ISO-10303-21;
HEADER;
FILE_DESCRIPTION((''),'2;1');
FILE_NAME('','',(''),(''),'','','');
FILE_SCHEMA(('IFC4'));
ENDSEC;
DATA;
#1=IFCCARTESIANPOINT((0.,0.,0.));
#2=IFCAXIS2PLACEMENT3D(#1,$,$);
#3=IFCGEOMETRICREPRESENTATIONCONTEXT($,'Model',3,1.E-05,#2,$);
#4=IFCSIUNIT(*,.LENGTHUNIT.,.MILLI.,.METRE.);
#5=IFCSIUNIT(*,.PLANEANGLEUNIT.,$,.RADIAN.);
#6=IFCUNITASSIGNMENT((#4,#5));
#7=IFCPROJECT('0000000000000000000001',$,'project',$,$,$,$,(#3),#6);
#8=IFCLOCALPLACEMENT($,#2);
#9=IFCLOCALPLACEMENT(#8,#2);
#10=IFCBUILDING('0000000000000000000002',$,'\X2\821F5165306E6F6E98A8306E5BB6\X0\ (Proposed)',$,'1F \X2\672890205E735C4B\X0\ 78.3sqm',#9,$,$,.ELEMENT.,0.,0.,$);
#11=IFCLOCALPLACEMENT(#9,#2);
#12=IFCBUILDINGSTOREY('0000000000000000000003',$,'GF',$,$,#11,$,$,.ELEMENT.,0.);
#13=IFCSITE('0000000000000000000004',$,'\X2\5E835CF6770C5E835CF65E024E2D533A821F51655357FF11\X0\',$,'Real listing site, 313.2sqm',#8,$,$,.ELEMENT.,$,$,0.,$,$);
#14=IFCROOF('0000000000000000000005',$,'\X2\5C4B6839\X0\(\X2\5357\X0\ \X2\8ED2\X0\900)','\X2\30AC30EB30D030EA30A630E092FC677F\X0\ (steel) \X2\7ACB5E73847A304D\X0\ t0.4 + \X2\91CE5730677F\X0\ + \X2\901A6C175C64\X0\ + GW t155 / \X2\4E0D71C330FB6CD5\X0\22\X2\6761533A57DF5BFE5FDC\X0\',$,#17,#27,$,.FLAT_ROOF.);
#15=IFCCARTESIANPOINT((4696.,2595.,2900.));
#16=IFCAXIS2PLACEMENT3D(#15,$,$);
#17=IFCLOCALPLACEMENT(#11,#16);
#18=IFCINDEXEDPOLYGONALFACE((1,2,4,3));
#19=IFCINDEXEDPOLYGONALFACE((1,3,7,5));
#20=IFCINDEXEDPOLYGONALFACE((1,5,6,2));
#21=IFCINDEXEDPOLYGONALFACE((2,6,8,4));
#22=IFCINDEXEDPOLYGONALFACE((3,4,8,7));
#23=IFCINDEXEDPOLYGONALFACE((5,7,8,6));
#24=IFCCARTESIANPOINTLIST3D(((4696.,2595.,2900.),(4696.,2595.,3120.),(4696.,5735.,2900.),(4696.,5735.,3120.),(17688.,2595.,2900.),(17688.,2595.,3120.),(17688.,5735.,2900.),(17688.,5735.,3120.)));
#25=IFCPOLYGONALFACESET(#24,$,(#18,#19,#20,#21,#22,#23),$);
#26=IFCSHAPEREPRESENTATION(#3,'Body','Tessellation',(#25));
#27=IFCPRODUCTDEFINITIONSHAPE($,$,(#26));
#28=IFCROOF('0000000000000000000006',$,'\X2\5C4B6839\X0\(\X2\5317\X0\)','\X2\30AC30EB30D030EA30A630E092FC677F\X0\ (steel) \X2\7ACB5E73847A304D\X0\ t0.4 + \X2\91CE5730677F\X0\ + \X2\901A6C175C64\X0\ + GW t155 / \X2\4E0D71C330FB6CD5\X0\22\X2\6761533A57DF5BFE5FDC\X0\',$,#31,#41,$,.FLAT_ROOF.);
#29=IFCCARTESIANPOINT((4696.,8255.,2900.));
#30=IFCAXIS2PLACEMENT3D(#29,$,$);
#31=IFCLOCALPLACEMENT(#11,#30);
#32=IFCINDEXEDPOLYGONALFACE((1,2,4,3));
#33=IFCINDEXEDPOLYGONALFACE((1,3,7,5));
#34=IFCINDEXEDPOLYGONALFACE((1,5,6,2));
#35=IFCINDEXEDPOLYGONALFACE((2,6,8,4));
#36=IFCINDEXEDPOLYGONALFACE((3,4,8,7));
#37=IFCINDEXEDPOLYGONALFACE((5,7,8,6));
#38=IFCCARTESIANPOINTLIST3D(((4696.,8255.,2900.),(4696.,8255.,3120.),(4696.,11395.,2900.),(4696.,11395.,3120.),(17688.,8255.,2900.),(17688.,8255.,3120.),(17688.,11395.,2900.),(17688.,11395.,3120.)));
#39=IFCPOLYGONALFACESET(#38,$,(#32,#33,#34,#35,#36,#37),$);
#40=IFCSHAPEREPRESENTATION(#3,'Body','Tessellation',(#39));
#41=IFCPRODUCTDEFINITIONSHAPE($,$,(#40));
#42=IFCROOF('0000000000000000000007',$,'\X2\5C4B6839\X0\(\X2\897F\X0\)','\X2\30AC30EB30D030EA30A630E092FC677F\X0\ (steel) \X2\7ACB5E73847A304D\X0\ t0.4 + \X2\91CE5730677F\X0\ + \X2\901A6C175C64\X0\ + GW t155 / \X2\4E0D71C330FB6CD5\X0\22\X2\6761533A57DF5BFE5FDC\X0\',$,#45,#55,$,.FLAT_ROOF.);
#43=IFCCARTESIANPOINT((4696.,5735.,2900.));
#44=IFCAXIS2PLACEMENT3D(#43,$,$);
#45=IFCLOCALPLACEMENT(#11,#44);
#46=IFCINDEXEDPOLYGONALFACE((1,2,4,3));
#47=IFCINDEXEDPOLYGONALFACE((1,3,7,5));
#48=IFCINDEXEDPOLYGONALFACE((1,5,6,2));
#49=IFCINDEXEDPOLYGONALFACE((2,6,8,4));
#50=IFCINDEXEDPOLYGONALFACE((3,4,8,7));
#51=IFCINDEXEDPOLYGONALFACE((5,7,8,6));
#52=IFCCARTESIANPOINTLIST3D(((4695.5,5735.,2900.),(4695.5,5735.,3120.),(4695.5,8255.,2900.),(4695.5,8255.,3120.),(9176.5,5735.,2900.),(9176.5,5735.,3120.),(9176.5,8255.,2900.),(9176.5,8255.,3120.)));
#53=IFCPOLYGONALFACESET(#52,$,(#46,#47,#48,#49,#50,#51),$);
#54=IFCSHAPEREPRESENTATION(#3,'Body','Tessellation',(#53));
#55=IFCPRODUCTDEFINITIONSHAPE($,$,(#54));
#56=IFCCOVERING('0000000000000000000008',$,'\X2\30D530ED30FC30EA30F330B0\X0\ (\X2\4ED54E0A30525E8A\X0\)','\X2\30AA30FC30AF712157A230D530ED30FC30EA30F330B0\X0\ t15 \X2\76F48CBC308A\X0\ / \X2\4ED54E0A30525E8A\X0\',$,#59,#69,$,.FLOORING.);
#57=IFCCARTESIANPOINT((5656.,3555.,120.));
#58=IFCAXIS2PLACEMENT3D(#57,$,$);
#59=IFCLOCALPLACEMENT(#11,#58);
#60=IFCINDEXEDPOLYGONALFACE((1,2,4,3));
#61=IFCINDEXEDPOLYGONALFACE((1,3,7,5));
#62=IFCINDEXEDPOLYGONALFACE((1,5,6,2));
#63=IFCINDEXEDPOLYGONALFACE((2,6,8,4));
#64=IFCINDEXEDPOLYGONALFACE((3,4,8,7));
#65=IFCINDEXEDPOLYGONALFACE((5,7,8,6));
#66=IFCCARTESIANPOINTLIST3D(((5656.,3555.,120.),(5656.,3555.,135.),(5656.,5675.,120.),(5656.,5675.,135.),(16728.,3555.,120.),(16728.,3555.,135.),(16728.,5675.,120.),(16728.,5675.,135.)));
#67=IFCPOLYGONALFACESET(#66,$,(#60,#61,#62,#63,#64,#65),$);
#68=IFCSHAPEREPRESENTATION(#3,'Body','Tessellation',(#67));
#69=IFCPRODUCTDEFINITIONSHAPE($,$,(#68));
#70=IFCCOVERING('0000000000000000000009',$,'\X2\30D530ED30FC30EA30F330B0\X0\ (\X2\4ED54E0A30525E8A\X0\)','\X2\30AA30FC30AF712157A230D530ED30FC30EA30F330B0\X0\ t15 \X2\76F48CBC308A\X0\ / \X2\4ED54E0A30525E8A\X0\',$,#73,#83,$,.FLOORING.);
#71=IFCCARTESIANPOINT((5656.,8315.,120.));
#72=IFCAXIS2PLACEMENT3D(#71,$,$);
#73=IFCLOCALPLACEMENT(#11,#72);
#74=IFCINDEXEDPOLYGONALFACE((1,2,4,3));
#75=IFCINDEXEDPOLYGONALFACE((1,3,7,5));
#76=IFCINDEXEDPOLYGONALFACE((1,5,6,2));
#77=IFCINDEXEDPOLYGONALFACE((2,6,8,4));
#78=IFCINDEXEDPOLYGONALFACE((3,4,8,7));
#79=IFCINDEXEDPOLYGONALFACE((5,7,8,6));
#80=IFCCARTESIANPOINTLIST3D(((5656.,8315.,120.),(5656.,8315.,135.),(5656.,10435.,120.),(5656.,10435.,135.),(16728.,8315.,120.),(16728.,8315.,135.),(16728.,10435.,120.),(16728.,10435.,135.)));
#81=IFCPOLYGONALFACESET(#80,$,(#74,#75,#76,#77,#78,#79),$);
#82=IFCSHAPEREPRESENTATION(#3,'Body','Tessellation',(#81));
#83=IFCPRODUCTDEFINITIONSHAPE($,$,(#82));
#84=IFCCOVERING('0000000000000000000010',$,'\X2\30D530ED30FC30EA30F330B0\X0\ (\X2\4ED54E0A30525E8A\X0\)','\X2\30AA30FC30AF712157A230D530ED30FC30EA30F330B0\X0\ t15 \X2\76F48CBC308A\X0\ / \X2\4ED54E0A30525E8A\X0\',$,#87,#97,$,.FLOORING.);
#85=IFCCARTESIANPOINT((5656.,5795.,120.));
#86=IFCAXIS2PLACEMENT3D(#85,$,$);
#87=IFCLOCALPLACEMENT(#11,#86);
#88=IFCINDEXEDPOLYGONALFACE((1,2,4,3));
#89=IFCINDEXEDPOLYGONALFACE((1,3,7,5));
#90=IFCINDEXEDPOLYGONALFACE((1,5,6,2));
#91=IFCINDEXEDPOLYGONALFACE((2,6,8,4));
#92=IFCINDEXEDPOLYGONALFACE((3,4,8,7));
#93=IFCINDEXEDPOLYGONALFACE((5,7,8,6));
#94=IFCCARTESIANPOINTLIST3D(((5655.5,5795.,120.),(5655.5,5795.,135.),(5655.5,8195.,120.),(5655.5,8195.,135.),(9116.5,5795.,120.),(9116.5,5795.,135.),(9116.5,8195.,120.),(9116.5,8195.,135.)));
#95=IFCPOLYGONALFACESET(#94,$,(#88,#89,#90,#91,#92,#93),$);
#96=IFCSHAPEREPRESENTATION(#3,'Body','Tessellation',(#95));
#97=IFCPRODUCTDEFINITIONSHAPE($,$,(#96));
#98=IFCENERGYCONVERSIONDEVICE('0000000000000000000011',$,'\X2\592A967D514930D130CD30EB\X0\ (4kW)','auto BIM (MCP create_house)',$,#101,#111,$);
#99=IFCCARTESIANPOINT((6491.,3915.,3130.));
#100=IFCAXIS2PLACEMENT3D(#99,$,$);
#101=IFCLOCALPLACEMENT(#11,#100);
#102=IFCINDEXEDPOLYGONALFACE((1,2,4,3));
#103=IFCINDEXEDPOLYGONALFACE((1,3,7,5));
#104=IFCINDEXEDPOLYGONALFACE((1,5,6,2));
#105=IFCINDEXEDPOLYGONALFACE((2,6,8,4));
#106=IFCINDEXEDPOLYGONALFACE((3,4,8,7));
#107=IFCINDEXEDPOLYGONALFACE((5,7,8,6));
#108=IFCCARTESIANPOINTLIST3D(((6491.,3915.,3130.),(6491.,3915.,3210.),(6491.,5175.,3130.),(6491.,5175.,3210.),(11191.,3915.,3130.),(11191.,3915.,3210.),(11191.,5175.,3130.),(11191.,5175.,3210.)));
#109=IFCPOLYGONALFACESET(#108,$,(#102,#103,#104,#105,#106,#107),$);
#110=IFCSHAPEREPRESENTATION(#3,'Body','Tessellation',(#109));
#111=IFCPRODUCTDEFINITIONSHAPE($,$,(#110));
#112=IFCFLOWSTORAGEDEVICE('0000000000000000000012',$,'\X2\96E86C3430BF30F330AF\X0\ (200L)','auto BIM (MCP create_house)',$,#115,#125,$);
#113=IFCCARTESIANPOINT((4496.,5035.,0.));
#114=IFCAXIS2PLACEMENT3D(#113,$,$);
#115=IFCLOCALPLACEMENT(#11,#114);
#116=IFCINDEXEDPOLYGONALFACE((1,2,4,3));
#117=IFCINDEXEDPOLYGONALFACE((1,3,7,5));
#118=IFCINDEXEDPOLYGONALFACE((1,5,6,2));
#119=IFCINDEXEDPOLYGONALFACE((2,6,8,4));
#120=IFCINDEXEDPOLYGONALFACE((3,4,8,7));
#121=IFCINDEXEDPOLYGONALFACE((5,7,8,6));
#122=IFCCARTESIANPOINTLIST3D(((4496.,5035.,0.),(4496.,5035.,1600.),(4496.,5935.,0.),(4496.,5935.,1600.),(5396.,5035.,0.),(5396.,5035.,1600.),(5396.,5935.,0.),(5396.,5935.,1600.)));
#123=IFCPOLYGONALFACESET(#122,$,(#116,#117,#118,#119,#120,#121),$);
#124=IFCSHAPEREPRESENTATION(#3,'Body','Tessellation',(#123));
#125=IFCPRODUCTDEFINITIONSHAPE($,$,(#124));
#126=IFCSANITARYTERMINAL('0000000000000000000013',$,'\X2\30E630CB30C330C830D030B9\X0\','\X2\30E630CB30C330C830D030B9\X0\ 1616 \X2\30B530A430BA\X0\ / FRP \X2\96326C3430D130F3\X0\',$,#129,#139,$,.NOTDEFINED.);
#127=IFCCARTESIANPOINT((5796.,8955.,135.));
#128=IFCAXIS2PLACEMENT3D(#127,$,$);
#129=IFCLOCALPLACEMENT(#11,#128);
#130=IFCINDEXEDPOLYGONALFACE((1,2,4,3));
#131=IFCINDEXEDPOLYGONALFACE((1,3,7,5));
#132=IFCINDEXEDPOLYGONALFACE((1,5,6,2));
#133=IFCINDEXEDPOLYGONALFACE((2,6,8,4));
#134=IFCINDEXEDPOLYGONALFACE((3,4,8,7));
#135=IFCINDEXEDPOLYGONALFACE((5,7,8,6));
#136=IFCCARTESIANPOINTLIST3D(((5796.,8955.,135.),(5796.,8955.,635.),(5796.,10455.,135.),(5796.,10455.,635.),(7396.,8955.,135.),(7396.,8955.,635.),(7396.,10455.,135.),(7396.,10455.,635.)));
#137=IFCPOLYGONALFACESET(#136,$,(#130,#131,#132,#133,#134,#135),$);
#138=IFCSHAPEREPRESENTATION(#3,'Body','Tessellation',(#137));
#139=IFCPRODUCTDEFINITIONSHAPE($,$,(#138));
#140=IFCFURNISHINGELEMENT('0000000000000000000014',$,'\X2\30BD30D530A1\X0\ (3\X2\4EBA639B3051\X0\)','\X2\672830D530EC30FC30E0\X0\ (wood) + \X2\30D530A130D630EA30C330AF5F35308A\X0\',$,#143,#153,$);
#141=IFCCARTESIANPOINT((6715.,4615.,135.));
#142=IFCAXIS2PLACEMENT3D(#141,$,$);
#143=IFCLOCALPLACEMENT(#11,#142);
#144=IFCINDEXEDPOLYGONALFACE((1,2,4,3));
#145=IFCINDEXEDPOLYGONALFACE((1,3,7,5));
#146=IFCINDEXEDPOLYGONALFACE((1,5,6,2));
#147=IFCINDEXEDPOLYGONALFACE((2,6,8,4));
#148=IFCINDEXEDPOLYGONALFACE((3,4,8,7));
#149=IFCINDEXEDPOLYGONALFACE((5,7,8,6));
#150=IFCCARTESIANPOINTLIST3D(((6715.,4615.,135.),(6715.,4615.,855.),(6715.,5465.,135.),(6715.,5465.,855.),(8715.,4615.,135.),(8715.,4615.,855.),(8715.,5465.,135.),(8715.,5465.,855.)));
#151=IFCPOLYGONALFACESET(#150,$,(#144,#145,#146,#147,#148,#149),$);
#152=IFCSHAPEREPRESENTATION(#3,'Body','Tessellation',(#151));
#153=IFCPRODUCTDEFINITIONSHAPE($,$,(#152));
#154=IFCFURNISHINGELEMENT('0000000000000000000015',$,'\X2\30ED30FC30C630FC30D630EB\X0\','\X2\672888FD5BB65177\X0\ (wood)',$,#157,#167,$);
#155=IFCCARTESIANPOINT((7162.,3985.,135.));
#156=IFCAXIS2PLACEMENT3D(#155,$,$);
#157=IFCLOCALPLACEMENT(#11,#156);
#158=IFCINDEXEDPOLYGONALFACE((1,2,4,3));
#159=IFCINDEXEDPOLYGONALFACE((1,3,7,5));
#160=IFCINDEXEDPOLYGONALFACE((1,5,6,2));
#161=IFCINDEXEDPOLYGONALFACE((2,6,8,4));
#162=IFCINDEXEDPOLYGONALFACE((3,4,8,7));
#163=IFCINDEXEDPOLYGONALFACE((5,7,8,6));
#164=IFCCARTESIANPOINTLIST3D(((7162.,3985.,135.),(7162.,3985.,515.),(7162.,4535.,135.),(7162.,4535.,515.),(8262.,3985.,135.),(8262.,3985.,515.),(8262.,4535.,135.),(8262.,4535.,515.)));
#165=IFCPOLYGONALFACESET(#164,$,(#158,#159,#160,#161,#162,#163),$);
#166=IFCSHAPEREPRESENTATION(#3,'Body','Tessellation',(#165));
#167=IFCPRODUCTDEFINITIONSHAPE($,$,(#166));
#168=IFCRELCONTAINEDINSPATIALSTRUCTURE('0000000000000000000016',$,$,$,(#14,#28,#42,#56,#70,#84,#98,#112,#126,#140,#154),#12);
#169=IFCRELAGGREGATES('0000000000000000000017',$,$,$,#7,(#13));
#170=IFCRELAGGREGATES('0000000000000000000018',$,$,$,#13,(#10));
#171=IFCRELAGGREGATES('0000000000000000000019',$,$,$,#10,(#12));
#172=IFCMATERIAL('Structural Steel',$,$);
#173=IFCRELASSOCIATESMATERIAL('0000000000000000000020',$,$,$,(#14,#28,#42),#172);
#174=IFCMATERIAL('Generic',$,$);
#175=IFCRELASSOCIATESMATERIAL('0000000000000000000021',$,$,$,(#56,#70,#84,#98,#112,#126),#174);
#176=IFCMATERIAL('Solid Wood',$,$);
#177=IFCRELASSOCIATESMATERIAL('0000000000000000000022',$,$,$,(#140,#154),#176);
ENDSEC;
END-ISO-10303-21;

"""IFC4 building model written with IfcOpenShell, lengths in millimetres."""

from ifc_helpers import new_model, si_unit, frame, frame_2d, origin, place, context, project, spatial, rectangle, extrude, material, element, save


model = new_model("IFC4")

# Units and contexts
model_context = context("Model", 3, precision=1e-05, world=origin())
ifc_project = project(units=[si_unit("LENGTHUNIT", "METRE", prefix="MILLI"), si_unit("PLANEANGLEUNIT", "RADIAN")], contexts=[model_context])

# Site, building, storey
site_placement = place(None, origin())
site = spatial("IfcSite", under=ifc_project, at=site_placement, Name="広島県広島市中区舟入南１", ObjectType="Real listing site, 313.2sqm", CompositionType="ELEMENT", RefElevation=0.0)
building_placement = place(site_placement, origin())
building = spatial("IfcBuilding", under=site, at=building_placement, Name="舟入の潮風の家 (Proposed)", ObjectType="1F 木造平屋 78.3sqm", CompositionType="ELEMENT", ElevationOfRefHeight=0.0, ElevationOfTerrain=0.0)
storey_placement = place(building_placement, origin())
storey = spatial("IfcBuildingStorey", under=building, at=storey_placement, Name="GF", CompositionType="ELEMENT", Elevation=0.0)

# Shared definitions
ifc_material_1 = material(Name="Solid Wood")

# Roofs
ifc_material_2 = material(Name="Structural Steel")
roof_1_placement = place(storey_placement, frame((4696.0, 2595.0, 2900.0)))
element("IfcRoof", 1, at=roof_1_placement, inside=storey, material=ifc_material_2, Name="屋根(南 軒900)", Description="ガルバリウム鋼板 (steel) 立平葺き t0.4 + 野地板 + 通気層 + GW t155 / 不燃・法22条区域対応", PredefinedType="FLAT_ROOF", context=model_context, shape_type="SweptSolid", body=[
    extrude(rectangle(XDim=12992.0, YDim=3140.0, at=frame_2d((6496.0, 1570.0))), frame((4696.0, 2595.0, 2900.0)), (0.0, 0.0, 1.0), 220.0),
])
roof_2_placement = place(storey_placement, frame((4696.0, 8255.0, 2900.0)))
element("IfcRoof", 2, at=roof_2_placement, inside=storey, material=ifc_material_2, Name="屋根(北)", Description="ガルバリウム鋼板 (steel) 立平葺き t0.4 + 野地板 + 通気層 + GW t155 / 不燃・法22条区域対応", PredefinedType="FLAT_ROOF", context=model_context, shape_type="SweptSolid", body=[
    extrude(rectangle(XDim=12992.0, YDim=3140.0, at=frame_2d((6496.0, 1570.0))), frame((4696.0, 8255.0, 2900.0)), (0.0, 0.0, 1.0), 220.0),
])
roof_3_placement = place(storey_placement, frame((4696.0, 5735.0, 2900.0)))
element("IfcRoof", 3, at=roof_3_placement, inside=storey, material=ifc_material_2, Name="屋根(西)", Description="ガルバリウム鋼板 (steel) 立平葺き t0.4 + 野地板 + 通気層 + GW t155 / 不燃・法22条区域対応", PredefinedType="FLAT_ROOF", context=model_context, shape_type="SweptSolid", body=[
    extrude(rectangle(XDim=4481.0, YDim=2520.0, at=frame_2d((2240.0, 1260.0))), frame((4696.0, 5735.0, 2900.0)), (0.0, 0.0, 1.0), 220.0),
])

# Coverings
ifc_material_3 = material(Name="Generic")
covering_1_placement = place(storey_placement, frame((5656.0, 3555.0, 120.0)))
element("IfcCovering", 4, at=covering_1_placement, inside=storey, material=ifc_material_3, Name="フローリング (仕上げ床)", Description="オーク無垢フローリング t15 直貼り / 仕上げ床", PredefinedType="FLOORING", context=model_context, shape_type="SweptSolid", body=[
    extrude(rectangle(XDim=11072.0, YDim=2120.0, at=frame_2d((5536.0, 1060.0))), frame((5656.0, 3555.0, 120.0)), (0.0, 0.0, 1.0), 15.0),
])
covering_2_placement = place(storey_placement, frame((5656.0, 8315.0, 120.0)))
element("IfcCovering", 5, at=covering_2_placement, inside=storey, material=ifc_material_3, Name="フローリング (仕上げ床)", Description="オーク無垢フローリング t15 直貼り / 仕上げ床", PredefinedType="FLOORING", context=model_context, shape_type="SweptSolid", body=[
    extrude(rectangle(XDim=11072.0, YDim=2120.0, at=frame_2d((5536.0, 1060.0))), frame((5656.0, 8315.0, 120.0)), (0.0, 0.0, 1.0), 15.0),
])
covering_3_placement = place(storey_placement, frame((5656.0, 5795.0, 120.0)))
element("IfcCovering", 6, at=covering_3_placement, inside=storey, material=ifc_material_3, Name="フローリング (仕上げ床)", Description="オーク無垢フローリング t15 直貼り / 仕上げ床", PredefinedType="FLOORING", context=model_context, shape_type="SweptSolid", body=[
    extrude(rectangle(XDim=3461.0, YDim=2400.0, at=frame_2d((1730.0, 1200.0))), frame((5656.0, 5795.0, 120.0)), (0.0, 0.0, 1.0), 15.0),
])

# Energy conversion device
energy_conversion_device_placement = place(storey_placement, frame((6491.0, 3915.0, 3130.0)))
element("IfcEnergyConversionDevice", 7, at=energy_conversion_device_placement, inside=storey, material=ifc_material_3, Name="太陽光パネル (4kW)", Description="auto BIM (MCP create_house)", context=model_context, shape_type="SweptSolid", body=[
    extrude(rectangle(XDim=4700.0, YDim=1260.0, at=frame_2d((2350.0, 630.0))), frame((6491.0, 3915.0, 3130.0)), (0.0, 0.0, 1.0), 80.0),
])

# Flow storage device
flow_storage_device_placement = place(storey_placement, frame((4496.0, 5035.0, 0.0)))
element("IfcFlowStorageDevice", 8, at=flow_storage_device_placement, inside=storey, material=ifc_material_3, Name="雨水タンク (200L)", Description="auto BIM (MCP create_house)", context=model_context, shape_type="SweptSolid", body=[
    extrude(rectangle(XDim=900.0, YDim=900.0, at=frame_2d((450.0, 450.0))), frame((4496.0, 5035.0, 0.0)), (0.0, 0.0, 1.0), 1600.0),
])

# Sanitary terminal
sanitary_terminal_placement = place(storey_placement, frame((5796.0, 8955.0, 135.0)))
element("IfcSanitaryTerminal", 9, at=sanitary_terminal_placement, inside=storey, material=ifc_material_3, Name="ユニットバス", Description="ユニットバス 1616 サイズ / FRP 防水パン", PredefinedType="NOTDEFINED", context=model_context, shape_type="SweptSolid", body=[
    extrude(rectangle(XDim=1600.0, YDim=1500.0, at=frame_2d((800.0, 750.0))), frame((5796.0, 8955.0, 135.0)), (0.0, 0.0, 1.0), 500.0),
])

# Furnishing elements
furnishing_1_placement = place(storey_placement, frame((6715.0, 4615.0, 135.0)))
element("IfcFurnishingElement", 10, at=furnishing_1_placement, inside=storey, material=ifc_material_1, Name="ソファ (3人掛け)", Description="木フレーム (wood) + ファブリック張り", context=model_context, shape_type="SweptSolid", body=[
    extrude(rectangle(XDim=2000.0, YDim=850.0, at=frame_2d((1000.0, 425.0))), frame((6715.0, 4615.0, 135.0)), (0.0, 0.0, 1.0), 720.0),
])
furnishing_2_placement = place(storey_placement, frame((7162.0, 3985.0, 135.0)))
element("IfcFurnishingElement", 11, at=furnishing_2_placement, inside=storey, material=ifc_material_1, Name="ローテーブル", Description="木製家具 (wood)", context=model_context, shape_type="SweptSolid", body=[
    extrude(rectangle(XDim=1100.0, YDim=550.0, at=frame_2d((550.0, 275.0))), frame((7162.0, 3985.0, 135.0)), (0.0, 0.0, 1.0), 380.0),
])

save(model, "model.ifc")
